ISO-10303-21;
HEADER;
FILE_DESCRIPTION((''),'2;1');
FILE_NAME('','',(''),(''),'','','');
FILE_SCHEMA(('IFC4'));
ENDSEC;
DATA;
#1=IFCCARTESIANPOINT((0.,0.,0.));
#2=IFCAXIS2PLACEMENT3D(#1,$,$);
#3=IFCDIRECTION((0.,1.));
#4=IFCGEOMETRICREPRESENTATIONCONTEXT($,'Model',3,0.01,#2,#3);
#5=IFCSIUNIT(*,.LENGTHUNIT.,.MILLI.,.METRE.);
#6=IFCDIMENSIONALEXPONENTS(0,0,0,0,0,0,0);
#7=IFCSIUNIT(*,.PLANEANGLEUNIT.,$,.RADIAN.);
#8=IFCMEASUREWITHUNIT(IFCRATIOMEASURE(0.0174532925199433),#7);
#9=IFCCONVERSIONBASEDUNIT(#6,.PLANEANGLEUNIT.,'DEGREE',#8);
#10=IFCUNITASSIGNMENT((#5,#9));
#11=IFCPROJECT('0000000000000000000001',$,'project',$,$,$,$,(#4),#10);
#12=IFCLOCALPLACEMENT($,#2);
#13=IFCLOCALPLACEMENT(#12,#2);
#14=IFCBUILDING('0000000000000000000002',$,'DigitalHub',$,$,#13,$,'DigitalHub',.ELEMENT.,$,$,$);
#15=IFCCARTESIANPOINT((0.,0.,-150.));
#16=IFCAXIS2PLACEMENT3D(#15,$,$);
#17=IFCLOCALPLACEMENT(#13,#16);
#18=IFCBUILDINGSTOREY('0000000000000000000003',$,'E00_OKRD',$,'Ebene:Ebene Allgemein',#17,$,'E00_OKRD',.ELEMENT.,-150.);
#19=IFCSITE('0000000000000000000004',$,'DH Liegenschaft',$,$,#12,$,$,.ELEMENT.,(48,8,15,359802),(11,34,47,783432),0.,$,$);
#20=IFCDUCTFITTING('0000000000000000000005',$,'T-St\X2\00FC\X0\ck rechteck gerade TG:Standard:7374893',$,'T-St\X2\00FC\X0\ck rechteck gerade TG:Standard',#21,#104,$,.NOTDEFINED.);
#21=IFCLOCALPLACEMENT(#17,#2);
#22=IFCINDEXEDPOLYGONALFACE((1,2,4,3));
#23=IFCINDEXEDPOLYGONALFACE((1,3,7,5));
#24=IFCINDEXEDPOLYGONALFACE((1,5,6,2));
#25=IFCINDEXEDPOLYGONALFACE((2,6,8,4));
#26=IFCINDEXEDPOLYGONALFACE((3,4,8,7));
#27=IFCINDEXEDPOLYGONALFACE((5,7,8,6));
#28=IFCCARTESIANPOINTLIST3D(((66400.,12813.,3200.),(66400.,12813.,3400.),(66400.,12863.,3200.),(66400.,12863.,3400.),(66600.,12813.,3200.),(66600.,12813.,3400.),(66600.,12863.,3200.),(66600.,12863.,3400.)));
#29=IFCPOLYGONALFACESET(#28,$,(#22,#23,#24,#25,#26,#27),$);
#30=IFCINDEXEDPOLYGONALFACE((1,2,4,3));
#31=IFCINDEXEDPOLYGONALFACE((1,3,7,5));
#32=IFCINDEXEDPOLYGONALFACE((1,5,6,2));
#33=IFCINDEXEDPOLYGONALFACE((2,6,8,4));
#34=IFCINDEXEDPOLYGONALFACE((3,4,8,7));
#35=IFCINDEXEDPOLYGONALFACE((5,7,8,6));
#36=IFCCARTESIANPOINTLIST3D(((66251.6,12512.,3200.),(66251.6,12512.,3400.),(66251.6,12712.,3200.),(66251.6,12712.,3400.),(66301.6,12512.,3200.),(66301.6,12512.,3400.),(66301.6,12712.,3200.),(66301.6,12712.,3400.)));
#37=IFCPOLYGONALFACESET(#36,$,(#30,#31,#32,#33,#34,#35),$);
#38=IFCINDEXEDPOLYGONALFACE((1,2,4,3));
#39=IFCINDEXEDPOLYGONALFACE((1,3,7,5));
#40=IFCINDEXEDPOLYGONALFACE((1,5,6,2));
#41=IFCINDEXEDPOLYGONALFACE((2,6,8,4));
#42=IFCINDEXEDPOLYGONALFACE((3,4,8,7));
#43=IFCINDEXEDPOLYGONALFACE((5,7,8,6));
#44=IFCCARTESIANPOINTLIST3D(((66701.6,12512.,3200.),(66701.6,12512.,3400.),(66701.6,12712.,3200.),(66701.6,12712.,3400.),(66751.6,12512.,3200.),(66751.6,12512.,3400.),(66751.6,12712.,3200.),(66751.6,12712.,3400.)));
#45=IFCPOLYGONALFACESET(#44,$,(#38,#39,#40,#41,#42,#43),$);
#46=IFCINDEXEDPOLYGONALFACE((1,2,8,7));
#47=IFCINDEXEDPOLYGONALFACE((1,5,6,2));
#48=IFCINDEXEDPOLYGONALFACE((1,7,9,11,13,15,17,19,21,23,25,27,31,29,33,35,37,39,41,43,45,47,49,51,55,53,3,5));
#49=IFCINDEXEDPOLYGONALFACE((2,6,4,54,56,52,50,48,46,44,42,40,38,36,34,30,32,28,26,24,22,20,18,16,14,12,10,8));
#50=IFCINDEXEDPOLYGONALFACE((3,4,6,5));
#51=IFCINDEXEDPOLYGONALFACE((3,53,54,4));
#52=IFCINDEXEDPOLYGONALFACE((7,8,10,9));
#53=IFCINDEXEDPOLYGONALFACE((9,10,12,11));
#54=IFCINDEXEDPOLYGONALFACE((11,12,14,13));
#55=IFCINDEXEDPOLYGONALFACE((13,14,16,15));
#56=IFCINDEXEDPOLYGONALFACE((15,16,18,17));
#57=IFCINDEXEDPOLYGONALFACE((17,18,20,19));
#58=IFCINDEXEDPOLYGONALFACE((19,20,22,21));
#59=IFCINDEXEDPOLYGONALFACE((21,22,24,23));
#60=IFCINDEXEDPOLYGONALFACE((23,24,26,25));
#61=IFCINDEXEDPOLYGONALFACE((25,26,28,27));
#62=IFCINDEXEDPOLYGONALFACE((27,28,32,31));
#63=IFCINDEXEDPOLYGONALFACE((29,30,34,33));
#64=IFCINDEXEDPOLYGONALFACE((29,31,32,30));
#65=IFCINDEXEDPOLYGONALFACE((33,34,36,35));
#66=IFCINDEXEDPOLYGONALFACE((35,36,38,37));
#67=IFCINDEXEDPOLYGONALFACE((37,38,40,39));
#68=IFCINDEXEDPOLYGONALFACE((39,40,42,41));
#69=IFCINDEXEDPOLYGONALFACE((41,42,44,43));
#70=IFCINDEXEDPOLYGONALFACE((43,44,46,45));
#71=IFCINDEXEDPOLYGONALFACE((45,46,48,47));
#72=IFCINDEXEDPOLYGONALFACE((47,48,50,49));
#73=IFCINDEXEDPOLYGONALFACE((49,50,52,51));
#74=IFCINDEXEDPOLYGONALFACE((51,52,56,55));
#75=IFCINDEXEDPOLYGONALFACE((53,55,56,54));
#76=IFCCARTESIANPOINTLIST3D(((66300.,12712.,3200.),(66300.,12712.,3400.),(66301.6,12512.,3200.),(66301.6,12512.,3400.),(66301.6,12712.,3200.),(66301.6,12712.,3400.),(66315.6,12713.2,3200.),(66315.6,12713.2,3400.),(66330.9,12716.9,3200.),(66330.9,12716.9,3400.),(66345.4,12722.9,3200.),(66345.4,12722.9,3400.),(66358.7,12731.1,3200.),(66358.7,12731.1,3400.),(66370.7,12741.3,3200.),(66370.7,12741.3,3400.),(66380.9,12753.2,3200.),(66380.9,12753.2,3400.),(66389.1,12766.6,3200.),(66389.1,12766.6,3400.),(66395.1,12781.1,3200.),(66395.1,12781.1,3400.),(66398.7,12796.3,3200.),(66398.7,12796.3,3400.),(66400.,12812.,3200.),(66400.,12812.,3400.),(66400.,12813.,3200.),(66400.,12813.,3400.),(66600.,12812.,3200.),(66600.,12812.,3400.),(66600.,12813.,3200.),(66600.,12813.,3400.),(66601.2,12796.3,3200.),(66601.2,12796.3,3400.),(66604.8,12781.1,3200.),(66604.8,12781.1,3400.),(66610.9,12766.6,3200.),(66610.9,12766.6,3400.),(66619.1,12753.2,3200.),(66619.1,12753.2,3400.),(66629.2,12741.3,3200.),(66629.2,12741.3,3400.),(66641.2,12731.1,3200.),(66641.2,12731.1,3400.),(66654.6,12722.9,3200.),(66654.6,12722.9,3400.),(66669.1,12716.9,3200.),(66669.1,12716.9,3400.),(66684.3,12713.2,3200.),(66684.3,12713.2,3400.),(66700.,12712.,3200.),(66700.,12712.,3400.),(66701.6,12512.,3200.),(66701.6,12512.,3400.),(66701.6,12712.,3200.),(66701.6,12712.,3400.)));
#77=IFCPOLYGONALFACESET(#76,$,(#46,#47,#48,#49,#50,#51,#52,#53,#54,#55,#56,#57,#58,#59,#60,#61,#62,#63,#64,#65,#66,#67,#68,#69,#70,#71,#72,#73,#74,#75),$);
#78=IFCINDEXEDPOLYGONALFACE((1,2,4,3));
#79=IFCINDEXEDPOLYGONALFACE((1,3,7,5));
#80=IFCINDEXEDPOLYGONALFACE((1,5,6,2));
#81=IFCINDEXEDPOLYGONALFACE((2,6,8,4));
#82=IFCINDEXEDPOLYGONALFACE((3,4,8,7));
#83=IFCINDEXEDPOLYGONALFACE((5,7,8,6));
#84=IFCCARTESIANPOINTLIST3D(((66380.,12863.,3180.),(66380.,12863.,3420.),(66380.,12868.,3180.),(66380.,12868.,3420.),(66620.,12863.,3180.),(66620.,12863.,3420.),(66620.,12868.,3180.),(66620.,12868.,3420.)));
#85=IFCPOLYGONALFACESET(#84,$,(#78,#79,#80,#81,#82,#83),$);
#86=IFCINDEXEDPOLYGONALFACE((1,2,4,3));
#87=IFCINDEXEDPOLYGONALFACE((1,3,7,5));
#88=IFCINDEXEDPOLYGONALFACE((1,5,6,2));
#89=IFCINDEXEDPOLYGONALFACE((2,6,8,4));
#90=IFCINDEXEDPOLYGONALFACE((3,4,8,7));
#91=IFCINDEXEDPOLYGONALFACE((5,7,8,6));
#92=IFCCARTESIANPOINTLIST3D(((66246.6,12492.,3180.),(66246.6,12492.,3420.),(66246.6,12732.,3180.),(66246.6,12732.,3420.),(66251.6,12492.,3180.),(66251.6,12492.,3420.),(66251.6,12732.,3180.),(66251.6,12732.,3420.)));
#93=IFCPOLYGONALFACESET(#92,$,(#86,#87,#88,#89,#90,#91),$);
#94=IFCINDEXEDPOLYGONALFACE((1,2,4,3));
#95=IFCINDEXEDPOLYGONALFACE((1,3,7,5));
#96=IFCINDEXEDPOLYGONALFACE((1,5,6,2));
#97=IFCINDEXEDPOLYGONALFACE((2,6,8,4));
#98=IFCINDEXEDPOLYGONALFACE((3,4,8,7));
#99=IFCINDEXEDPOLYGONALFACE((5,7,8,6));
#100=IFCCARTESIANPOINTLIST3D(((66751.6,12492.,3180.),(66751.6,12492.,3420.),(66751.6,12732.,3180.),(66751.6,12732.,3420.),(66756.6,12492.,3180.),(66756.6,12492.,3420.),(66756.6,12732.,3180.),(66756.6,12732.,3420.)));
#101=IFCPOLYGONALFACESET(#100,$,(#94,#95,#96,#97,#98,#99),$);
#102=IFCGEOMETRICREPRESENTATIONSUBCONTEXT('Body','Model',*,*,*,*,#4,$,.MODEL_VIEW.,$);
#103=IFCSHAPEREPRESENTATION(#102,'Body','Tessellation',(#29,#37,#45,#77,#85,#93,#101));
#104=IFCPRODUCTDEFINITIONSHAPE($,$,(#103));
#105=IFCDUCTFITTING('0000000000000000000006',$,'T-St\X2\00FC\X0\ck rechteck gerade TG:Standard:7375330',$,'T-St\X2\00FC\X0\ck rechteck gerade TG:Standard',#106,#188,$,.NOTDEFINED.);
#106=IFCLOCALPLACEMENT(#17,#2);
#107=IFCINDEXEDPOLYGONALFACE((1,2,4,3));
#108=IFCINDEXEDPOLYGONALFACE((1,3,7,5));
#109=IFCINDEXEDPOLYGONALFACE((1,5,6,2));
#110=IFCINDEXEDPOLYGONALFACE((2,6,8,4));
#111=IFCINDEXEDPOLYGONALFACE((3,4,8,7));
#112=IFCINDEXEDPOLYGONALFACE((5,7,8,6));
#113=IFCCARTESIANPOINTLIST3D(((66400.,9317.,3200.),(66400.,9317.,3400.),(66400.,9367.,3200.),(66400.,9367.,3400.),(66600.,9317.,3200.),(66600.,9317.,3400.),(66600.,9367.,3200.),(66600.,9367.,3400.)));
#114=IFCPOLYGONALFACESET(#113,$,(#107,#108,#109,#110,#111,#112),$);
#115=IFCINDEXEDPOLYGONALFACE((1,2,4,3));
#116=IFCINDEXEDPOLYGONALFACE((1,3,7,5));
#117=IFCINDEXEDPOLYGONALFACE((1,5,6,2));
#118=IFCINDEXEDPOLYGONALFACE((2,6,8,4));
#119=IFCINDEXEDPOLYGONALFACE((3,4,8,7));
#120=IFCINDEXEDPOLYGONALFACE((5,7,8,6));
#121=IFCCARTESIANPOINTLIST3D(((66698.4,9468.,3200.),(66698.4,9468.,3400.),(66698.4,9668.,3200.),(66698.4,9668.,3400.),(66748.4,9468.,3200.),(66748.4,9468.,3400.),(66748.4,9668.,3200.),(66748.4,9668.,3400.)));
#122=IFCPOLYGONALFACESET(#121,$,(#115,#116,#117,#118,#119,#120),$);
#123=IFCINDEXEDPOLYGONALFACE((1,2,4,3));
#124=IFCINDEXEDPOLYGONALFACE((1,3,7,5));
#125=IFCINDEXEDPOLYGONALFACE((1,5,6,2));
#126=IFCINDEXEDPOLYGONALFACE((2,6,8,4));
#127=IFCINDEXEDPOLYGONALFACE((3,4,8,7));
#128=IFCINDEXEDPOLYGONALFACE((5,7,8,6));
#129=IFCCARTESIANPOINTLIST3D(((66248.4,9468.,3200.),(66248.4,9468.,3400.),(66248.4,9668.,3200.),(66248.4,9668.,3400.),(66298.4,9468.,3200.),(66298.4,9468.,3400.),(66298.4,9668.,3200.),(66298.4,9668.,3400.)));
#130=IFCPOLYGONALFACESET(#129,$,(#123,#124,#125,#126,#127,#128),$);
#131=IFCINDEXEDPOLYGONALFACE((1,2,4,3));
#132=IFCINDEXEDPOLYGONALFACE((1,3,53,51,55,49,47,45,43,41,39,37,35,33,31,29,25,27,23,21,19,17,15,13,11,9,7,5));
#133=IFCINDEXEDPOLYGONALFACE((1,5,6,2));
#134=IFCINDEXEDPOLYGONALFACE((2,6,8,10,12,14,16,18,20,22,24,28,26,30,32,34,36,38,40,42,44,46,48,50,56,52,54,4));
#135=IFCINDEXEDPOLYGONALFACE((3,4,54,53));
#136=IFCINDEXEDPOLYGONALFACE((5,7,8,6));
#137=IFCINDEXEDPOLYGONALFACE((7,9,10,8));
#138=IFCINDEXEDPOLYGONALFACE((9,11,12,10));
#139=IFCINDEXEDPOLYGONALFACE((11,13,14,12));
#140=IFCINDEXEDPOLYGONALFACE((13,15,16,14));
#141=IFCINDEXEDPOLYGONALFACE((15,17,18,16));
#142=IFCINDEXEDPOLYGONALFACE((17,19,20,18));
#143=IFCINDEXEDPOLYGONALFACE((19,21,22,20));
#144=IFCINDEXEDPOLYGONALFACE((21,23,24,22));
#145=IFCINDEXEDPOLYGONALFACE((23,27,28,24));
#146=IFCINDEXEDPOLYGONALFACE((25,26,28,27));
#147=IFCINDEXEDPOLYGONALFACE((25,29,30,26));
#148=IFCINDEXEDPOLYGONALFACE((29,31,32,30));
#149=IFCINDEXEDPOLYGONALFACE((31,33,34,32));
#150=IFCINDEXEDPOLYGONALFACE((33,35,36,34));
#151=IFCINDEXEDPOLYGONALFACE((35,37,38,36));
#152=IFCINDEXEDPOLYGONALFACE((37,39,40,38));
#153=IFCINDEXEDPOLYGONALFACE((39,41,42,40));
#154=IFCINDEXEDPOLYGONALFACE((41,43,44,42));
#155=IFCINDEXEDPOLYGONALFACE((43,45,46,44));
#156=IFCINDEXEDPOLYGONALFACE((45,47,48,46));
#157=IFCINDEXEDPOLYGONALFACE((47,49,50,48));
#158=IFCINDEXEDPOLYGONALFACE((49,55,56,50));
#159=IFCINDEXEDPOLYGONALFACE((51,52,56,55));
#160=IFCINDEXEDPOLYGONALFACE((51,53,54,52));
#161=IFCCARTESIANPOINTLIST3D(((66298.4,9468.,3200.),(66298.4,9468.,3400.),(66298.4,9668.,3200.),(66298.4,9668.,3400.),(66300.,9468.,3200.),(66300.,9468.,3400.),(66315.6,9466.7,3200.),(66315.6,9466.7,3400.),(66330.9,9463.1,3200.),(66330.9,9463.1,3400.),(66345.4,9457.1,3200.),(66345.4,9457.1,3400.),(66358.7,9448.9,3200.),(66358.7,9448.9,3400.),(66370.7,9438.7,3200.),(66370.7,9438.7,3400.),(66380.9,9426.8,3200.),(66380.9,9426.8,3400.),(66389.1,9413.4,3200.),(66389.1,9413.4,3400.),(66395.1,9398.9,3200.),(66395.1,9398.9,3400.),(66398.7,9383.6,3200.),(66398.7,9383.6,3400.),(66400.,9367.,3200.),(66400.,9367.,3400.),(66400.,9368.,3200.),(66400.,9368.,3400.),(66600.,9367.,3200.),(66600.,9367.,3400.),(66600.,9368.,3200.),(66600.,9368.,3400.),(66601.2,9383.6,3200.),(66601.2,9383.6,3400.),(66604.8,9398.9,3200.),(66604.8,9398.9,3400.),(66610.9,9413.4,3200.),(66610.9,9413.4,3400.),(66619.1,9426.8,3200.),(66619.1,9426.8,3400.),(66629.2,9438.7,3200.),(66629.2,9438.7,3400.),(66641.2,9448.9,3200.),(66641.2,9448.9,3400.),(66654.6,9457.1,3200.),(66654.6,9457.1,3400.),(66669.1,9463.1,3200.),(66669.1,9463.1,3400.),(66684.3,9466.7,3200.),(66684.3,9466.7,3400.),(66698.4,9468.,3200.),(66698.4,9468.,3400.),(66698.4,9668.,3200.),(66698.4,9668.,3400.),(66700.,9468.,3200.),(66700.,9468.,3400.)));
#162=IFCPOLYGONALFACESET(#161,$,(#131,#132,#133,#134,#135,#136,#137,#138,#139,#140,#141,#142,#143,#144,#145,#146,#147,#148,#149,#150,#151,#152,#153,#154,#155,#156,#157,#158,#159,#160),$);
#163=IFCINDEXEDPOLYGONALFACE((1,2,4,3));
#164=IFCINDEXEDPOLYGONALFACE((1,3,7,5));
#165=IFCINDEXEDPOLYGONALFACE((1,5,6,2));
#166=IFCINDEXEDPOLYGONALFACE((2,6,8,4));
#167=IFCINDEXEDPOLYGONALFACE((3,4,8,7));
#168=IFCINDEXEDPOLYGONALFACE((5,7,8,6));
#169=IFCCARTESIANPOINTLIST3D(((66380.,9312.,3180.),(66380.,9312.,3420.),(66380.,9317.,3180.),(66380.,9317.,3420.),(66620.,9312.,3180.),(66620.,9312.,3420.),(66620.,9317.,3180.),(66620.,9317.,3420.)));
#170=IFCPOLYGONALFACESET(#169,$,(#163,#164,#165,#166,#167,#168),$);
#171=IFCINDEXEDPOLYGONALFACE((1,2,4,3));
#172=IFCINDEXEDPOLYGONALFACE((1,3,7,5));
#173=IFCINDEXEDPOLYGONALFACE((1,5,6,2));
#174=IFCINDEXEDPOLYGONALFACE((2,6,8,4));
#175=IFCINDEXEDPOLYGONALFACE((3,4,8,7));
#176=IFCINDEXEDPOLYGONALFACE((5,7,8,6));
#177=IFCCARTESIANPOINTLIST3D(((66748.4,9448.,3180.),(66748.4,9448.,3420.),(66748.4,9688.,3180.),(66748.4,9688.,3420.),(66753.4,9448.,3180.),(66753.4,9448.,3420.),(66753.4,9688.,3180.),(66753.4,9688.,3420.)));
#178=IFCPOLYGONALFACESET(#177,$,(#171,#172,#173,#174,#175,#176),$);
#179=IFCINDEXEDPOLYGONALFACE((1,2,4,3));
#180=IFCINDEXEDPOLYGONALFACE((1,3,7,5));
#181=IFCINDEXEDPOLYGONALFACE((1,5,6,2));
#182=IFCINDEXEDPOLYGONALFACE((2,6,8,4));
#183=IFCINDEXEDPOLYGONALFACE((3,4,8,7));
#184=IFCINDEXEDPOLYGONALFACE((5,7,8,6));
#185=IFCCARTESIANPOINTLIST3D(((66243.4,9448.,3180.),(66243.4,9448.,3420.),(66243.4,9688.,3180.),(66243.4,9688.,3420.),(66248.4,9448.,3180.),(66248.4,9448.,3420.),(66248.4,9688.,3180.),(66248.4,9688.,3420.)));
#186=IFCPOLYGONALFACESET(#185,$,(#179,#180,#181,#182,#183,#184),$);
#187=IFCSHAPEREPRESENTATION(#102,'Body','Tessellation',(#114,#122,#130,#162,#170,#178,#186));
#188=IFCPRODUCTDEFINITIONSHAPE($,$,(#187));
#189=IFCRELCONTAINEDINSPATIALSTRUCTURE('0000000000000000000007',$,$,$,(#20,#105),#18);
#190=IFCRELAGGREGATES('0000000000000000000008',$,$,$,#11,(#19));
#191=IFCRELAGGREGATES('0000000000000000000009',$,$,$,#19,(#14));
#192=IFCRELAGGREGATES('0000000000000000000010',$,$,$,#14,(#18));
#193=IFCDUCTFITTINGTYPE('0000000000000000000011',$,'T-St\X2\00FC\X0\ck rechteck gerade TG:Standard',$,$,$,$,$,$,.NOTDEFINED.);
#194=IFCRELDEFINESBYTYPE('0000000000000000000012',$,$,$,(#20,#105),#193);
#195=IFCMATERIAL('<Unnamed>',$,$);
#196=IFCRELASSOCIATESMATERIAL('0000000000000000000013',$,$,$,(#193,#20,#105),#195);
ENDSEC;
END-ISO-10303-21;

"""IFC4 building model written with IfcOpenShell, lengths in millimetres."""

from ifc_helpers import new_model, entity, si_unit, converted_unit, direction, frame, origin, place, context, subcontext, project, spatial, indexed_curve, outline, extrude, source, transform, mapped, material, type_object, type_shapes, element, save


model = new_model("IFC4")

# Units and contexts
model_context = context("Model", 3, precision=0.01, world=origin(), true_north=direction((0.0, 1.0)))
body_context = subcontext(model_context, "Body", "Model", "MODEL_VIEW")
ifc_project = project(units=[si_unit("LENGTHUNIT", "METRE", prefix="MILLI"), converted_unit("PLANEANGLEUNIT", "DEGREE", entity("IfcRatioMeasure", 0.0174532925199433), si_unit("PLANEANGLEUNIT", "RADIAN"), dimensions=[0, 0, 0, 0, 0, 0, 0])], contexts=[model_context])

# Site, building, storey
site_placement = place(None, origin())
site = spatial("IfcSite", under=ifc_project, at=site_placement, Name="DH Liegenschaft", CompositionType="ELEMENT", RefLatitude=(48, 8, 15, 359802), RefLongitude=(11, 34, 47, 783432), RefElevation=0.0)
building_placement = place(site_placement, origin())
building = spatial("IfcBuilding", under=site, at=building_placement, Name="DigitalHub", LongName="DigitalHub", CompositionType="ELEMENT")
storey_placement = place(building_placement, frame((0.0, 0.0, -150.0)))
storey = spatial("IfcBuildingStorey", under=building, at=storey_placement, Name="E00_OKRD", ObjectType="Ebene:Ebene Allgemein", LongName="E00_OKRD", CompositionType="ELEMENT", Elevation=-150.0)

# Shared definitions
ifc_material_1 = material(Name="<Unnamed>")

# Duct fittings
duct_fitting_type_1 = type_object("IfcDuctFittingType", Name="T-Stück rechteck gerade TG:Standard", PredefinedType="NOTDEFINED", material=ifc_material_1)
shared_shape_1 = source(origin(), body_context, "Body", "SweptSolid", [
    extrude(outline(indexed_curve([(-25.0, -100.0), (25.0, -100.0), (25.0, 100.0), (-25.0, 100.0), (-25.0, -100.0)], self_intersect=False)), frame((0.0, -226.0, -100.0), z_axis=(0.0, 0.0, 1.0), x_axis=(0.0, -1.0, 0.0)), (0.0, 0.0, 1.0), 200.0),
    extrude(outline(indexed_curve([(-25.0, -100.0), (25.0, -100.0), (25.0, 100.0), (-25.0, 100.0), (-25.0, -100.0)], self_intersect=False)), frame((223.4, 0.0, -100.0), z_axis=(0.0, 0.0, 1.0), x_axis=(-1.0, 0.0, 0.0)), (0.0, 0.0, 1.0), 200.0),
    extrude(outline(indexed_curve([(-25.0, -100.0), (25.0, -100.0), (25.0, 100.0), (-25.0, 100.0), (-25.0, -100.0)], self_intersect=False)), frame((-226.6, 0.0, -100.0)), (0.0, 0.0, 1.0), 200.0),
    extrude(outline(indexed_curve([(-200.6, 0.2), (-185.0, -1.0), (-169.7, -4.7), (-155.2, -10.7), (-141.9, -18.9), (-129.9, -29.1), (-119.7, -41.0), (-111.5, -54.4), (-105.5, -68.9), (-101.9, -84.2), (-100.6, -99.8), (-100.6, -100.8), (99.4, -100.8), (99.4, -99.8), (100.6, -84.2), (104.3, -68.9), (110.3, -54.4), (118.5, -41.0), (128.6, -29.1), (140.6, -18.9), (154.0, -10.7), (168.5, -4.7), (183.7, -1.0), (199.4, 0.2), (201.0, 0.2), (201.0, 200.2), (-199.0, 200.2), (-199.0, 0.2), (-200.6, 0.2)], self_intersect=False)), frame((-0.6, -100.2, -100.0), z_axis=(0.0, 0.0, -1.0), x_axis=(-1.0, 0.0, 0.0)), (0.0, 0.0, -1.0), 200.0),
    extrude(outline(indexed_curve([(-2.5, -120.0), (2.5, -120.0), (2.5, 120.0), (-2.5, 120.0), (-2.5, -120.0)], self_intersect=False)), frame((0.0, -253.5, -120.0), z_axis=(0.0, 0.0, 1.0), x_axis=(0.0, 1.0, 0.0)), (0.0, 0.0, 1.0), 240.0),
    extrude(outline(indexed_curve([(-2.5, -120.0), (2.5, -120.0), (2.5, 120.0), (-2.5, 120.0), (-2.5, -120.0)], self_intersect=False)), frame((250.9, 0.0, -120.0), z_axis=(0.0, 0.0, 1.0), x_axis=(-1.0, 0.0, 0.0)), (0.0, 0.0, 1.0), 240.0),
    extrude(outline(indexed_curve([(-2.5, -120.0), (2.5, -120.0), (2.5, 120.0), (-2.5, 120.0), (-2.5, -120.0)], self_intersect=False)), frame((-254.1, 0.0, -120.0), z_axis=(0.0, 0.0, 1.0), x_axis=(-1.0, 0.0, 0.0)), (0.0, 0.0, 1.0), 240.0),
])
type_shapes(duct_fitting_type_1, [shared_shape_1])
duct_fitting_1_placement = place(storey_placement, frame((66500.0, 12612.0, 3300.0), z_axis=(0.0, 0.0, 1.0), x_axis=(-1.0, 0.0, 0.0)))
element("IfcDuctFitting", 1, at=duct_fitting_1_placement, inside=storey, type_object=duct_fitting_type_1, material=ifc_material_1, Name="T-Stück rechteck gerade TG:Standard:7374893", ObjectType="T-Stück rechteck gerade TG:Standard", PredefinedType="NOTDEFINED", context=body_context, shape_type="MappedRepresentation", body=[
    mapped(shared_shape_1, transform((0.0, 0.0, 0.0), scale=1.0)),
])
duct_fitting_2_placement = place(storey_placement, frame((66500.0, 9568.0, 3300.0)))
element("IfcDuctFitting", 2, at=duct_fitting_2_placement, inside=storey, type_object=duct_fitting_type_1, material=ifc_material_1, Name="T-Stück rechteck gerade TG:Standard:7375330", ObjectType="T-Stück rechteck gerade TG:Standard", PredefinedType="NOTDEFINED", context=body_context, shape_type="MappedRepresentation", body=[
    mapped(shared_shape_1, transform((0.0, 0.0, 0.0), scale=1.0)),
])

save(model, "model.ifc")
